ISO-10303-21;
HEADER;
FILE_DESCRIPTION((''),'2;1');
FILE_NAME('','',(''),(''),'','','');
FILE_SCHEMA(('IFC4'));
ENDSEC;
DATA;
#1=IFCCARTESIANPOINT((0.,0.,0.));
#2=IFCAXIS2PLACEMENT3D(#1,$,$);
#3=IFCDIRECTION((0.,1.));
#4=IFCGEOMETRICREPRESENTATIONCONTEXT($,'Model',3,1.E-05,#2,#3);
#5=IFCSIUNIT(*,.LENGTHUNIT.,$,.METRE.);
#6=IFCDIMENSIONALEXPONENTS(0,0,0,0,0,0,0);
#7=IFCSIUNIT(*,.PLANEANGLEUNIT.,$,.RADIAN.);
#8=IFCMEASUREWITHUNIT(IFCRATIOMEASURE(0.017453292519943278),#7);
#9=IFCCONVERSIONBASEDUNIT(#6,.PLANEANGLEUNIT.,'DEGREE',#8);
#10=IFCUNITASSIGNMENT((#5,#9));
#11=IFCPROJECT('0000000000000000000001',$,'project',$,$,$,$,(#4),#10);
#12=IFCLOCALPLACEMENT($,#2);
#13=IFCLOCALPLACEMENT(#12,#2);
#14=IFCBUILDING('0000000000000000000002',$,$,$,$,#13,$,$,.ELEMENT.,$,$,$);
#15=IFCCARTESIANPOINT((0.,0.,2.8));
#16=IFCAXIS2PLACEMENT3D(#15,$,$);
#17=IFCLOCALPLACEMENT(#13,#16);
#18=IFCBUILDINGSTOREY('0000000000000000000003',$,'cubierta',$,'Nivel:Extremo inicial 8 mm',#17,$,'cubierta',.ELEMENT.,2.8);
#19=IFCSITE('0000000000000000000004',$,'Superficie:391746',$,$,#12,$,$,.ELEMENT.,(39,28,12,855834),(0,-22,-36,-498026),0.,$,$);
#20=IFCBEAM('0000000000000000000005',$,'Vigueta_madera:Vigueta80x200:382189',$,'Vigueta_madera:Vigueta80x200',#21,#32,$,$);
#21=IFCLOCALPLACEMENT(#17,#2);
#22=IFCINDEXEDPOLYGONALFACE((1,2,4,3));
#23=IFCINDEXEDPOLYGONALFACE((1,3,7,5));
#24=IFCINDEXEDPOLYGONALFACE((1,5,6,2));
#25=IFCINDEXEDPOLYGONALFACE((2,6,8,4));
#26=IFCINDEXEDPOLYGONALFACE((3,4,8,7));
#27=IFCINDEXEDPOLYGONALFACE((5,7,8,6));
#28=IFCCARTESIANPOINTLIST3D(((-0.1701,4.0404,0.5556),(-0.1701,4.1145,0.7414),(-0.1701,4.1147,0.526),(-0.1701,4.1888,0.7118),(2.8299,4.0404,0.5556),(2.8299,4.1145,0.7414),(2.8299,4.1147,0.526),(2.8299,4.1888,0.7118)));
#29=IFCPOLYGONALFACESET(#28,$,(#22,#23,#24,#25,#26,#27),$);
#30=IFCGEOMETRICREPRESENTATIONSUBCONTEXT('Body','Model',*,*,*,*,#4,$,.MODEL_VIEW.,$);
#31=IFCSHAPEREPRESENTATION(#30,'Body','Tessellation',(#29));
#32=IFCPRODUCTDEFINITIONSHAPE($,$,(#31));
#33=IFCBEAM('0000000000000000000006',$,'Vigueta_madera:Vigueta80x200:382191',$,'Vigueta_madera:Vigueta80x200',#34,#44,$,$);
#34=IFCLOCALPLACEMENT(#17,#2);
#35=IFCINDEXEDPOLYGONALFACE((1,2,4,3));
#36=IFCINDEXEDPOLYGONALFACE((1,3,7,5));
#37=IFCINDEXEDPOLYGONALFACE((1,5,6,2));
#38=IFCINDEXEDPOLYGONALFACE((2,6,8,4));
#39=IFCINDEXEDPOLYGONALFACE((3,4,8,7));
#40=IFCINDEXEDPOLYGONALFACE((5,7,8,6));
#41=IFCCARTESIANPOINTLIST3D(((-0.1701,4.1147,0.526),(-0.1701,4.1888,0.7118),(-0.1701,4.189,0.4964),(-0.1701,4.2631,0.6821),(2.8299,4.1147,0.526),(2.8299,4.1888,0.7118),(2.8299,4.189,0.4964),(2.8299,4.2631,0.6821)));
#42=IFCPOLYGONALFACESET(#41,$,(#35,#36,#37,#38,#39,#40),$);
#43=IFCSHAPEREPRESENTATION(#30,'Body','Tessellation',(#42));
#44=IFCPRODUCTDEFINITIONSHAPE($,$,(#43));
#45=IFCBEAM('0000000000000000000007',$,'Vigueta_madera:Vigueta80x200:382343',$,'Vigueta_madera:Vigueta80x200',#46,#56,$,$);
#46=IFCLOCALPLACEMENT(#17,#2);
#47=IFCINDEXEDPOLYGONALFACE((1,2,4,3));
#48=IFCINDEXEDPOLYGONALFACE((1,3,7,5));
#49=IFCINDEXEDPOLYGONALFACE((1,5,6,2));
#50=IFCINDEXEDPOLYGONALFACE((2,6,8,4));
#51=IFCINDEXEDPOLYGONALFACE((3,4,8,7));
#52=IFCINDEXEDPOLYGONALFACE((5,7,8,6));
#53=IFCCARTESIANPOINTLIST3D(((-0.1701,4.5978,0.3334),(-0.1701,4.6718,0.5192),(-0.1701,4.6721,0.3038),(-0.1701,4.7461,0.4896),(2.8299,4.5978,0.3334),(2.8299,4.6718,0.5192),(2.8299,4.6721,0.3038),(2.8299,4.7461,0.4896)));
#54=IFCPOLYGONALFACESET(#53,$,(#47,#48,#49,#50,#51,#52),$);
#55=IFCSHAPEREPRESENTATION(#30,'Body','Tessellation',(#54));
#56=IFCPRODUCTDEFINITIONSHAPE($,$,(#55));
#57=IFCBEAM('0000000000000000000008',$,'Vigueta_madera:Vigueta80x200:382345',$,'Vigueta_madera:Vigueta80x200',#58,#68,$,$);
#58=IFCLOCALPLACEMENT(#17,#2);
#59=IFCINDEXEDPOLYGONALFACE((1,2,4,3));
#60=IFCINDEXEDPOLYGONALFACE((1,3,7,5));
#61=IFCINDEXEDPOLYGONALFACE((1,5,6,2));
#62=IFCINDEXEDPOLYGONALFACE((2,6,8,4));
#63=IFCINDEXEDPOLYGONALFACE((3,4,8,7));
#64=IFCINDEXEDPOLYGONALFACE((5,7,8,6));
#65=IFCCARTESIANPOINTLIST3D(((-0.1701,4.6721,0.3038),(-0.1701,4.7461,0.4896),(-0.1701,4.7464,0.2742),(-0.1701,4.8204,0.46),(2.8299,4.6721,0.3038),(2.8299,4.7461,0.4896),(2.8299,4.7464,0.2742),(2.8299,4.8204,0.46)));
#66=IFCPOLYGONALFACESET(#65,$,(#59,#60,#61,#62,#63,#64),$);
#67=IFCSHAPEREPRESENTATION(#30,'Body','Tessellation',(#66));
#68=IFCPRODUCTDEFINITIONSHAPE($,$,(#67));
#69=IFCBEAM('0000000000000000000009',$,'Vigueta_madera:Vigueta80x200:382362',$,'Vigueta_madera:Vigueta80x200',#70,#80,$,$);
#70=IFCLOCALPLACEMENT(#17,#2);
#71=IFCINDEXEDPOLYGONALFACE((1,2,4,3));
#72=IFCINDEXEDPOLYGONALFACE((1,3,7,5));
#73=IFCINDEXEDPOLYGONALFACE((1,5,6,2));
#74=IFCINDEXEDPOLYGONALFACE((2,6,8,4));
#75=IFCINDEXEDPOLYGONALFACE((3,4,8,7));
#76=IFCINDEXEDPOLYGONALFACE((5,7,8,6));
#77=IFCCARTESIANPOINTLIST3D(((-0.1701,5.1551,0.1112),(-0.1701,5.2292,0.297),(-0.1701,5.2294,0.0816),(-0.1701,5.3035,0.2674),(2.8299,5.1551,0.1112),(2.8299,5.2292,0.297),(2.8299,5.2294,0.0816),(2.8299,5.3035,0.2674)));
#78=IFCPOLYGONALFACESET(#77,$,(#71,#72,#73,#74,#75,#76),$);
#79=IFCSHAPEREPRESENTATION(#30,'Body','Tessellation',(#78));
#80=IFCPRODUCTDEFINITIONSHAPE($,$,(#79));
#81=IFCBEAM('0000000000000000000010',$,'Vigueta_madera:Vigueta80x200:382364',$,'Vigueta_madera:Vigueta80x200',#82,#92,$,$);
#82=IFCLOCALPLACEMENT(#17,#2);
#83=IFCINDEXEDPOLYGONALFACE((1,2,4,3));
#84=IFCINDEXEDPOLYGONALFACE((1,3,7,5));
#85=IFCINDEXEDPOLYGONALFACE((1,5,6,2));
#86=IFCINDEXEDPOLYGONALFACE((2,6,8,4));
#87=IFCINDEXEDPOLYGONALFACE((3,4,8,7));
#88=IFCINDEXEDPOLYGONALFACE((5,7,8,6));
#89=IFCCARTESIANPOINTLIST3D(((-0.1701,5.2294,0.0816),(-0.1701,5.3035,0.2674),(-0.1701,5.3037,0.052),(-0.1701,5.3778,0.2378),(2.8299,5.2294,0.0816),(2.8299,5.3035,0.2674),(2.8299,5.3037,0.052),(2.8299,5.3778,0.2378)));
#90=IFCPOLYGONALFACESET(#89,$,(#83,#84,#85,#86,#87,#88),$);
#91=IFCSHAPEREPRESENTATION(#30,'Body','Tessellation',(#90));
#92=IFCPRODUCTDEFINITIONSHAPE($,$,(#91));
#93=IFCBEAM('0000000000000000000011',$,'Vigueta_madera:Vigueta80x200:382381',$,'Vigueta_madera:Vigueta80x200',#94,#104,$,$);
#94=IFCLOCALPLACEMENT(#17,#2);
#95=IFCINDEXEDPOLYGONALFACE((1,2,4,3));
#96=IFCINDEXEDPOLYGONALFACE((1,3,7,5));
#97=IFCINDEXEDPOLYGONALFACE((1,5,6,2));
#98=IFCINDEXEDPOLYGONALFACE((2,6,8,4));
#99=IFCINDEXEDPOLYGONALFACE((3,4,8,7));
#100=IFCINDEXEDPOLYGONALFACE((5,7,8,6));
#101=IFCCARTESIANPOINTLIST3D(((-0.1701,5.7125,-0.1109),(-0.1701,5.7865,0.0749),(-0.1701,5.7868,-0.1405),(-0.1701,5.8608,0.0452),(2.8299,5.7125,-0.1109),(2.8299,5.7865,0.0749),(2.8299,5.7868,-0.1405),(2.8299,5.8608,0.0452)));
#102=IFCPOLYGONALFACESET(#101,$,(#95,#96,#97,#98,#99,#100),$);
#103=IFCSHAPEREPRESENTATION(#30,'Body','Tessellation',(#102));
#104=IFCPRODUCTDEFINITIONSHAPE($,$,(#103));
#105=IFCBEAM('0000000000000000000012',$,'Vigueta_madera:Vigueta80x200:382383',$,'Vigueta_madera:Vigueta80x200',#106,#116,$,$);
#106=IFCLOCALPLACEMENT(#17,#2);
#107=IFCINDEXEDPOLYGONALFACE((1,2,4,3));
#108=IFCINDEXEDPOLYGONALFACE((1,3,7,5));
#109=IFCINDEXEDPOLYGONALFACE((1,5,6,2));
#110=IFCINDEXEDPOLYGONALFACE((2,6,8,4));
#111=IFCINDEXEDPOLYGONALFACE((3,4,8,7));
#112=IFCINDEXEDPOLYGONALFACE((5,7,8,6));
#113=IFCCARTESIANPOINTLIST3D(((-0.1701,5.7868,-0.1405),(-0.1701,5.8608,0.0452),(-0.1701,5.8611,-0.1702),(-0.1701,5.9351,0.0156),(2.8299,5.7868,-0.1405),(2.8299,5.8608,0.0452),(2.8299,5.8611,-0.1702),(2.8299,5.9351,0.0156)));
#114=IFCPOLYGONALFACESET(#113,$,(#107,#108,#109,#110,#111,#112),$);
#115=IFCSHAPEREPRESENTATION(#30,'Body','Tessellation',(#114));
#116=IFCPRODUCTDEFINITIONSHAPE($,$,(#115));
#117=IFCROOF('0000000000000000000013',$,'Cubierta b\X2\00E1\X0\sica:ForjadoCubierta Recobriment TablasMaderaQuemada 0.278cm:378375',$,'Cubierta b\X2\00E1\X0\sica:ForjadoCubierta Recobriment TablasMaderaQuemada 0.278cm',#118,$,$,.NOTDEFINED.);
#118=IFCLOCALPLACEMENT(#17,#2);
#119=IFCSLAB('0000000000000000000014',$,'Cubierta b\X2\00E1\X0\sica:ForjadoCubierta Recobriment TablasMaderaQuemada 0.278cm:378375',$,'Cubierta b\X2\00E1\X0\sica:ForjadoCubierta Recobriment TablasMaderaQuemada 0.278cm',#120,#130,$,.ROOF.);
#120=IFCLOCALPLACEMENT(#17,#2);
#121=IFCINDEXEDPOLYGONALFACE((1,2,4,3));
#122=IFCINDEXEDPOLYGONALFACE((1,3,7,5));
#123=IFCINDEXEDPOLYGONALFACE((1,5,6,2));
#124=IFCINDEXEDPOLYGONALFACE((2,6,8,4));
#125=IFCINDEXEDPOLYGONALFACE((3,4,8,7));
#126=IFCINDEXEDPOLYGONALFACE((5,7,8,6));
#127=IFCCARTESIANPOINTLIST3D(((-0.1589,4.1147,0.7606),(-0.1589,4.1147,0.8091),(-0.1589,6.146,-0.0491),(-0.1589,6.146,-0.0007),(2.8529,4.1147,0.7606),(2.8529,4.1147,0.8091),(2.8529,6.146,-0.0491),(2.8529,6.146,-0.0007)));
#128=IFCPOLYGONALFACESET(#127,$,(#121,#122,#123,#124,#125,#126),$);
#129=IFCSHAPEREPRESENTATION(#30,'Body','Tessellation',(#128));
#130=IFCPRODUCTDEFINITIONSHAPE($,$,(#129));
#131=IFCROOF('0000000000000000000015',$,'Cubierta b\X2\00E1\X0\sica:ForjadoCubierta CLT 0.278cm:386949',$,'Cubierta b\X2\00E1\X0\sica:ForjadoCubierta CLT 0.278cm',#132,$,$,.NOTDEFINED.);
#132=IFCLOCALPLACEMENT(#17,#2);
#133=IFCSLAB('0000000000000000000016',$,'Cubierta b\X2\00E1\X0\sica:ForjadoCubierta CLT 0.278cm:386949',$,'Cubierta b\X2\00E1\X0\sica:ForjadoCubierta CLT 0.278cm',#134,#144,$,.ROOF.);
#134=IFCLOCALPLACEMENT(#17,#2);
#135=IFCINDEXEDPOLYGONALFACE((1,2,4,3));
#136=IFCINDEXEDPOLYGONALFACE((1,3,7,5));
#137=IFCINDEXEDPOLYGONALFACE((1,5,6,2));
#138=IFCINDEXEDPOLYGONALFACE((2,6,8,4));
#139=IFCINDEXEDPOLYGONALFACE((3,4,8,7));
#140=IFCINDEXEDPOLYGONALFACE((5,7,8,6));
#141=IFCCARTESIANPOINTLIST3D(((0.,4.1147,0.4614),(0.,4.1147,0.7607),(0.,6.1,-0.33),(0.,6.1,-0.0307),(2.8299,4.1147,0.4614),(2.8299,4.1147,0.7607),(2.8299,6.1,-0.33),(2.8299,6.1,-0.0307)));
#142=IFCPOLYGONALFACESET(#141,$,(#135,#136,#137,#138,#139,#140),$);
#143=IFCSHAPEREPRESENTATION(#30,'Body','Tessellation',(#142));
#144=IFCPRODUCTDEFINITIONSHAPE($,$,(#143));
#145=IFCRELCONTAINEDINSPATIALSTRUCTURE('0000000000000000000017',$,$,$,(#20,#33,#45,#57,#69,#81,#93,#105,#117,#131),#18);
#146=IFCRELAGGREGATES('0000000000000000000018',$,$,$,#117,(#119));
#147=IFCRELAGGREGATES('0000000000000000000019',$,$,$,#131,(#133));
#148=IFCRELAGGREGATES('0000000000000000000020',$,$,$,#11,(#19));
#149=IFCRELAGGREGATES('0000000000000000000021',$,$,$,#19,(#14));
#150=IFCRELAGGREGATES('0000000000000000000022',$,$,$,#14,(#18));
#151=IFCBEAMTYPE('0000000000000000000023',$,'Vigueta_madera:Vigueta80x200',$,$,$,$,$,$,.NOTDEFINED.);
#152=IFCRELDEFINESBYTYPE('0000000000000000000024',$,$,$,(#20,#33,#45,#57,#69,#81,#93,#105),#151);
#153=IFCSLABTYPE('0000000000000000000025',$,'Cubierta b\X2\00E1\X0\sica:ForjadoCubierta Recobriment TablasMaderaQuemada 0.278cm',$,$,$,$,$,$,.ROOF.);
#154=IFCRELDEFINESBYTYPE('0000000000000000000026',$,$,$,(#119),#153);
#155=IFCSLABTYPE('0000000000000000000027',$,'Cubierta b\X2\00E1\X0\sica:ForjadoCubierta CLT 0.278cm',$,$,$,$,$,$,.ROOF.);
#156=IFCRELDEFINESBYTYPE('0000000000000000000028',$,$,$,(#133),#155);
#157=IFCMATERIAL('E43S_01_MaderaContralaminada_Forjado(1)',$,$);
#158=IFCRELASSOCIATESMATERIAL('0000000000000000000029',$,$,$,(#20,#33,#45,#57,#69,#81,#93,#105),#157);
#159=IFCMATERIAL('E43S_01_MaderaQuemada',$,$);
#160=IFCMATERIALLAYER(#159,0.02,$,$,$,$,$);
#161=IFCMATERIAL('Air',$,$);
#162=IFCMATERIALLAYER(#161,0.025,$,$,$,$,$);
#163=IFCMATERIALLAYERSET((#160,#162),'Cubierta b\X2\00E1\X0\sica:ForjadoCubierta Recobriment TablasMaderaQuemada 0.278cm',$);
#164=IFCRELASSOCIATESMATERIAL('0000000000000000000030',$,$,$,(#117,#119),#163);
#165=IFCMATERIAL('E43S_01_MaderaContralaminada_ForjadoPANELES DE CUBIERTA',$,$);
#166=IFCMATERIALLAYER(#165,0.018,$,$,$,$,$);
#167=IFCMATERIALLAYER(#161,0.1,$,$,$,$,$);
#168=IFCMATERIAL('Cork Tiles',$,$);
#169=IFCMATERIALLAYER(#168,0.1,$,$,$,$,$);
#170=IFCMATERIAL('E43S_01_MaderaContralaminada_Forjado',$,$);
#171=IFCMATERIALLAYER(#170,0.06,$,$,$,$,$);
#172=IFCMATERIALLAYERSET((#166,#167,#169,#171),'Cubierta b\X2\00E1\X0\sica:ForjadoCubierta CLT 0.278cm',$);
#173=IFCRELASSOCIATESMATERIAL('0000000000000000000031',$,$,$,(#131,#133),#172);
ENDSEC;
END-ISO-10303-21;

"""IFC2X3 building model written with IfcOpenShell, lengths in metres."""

from ifc_helpers import new_model, entity, si_unit, converted_unit, direction, frame, frame_2d, origin, place, context, subcontext, project, spatial, rectangle, extrude, material, layer, layer_set, type_object, element, aggregate, save


model = new_model("IFC2X3")

# Units and contexts
model_context = context("Model", 3, precision=1e-05, world=origin(), true_north=direction((0.0, 1.0)))
body_context = subcontext(model_context, "Body", "Model", "MODEL_VIEW")
ifc_project = project(units=[si_unit("LENGTHUNIT", "METRE"), converted_unit("PLANEANGLEUNIT", "DEGREE", entity("IfcRatioMeasure", 0.017453292519943278), si_unit("PLANEANGLEUNIT", "RADIAN"), dimensions=[0, 0, 0, 0, 0, 0, 0])], contexts=[model_context])

# Site, building, storey
site_placement = place(None, origin())
site = spatial("IfcSite", under=ifc_project, at=site_placement, Name="Superficie:391746", CompositionType="ELEMENT", RefLatitude=(39, 28, 12, 855834), RefLongitude=(0, -22, -36, -498026), RefElevation=0.0)
building_placement = place(site_placement, origin())
building = spatial("IfcBuilding", under=site, at=building_placement, CompositionType="ELEMENT")
storey_placement = place(building_placement, frame((0.0, 0.0, 2.8)))
storey = spatial("IfcBuildingStorey", under=building, at=storey_placement, Name="cubierta", ObjectType="Nivel:Extremo inicial 8 mm", LongName="cubierta", CompositionType="ELEMENT", Elevation=2.8)

# Beams
ifc_material_1 = material(Name="E43S_01_MaderaContralaminada_Forjado(1)")
beam_type = type_object("IfcBeamType", Name="Vigueta_madera:Vigueta80x200", PredefinedType="NOTDEFINED")
for number, where, name in (
    (1, (-0.1701, 4.1516, 0.7266), "Vigueta_madera:Vigueta80x200:382189"),
    (2, (-0.1701, 4.2259, 0.697), "Vigueta_madera:Vigueta80x200:382191"),
    (3, (-0.1701, 4.709, 0.5044), "Vigueta_madera:Vigueta80x200:382343"),
    (4, (-0.1701, 4.7833, 0.4748), "Vigueta_madera:Vigueta80x200:382345"),
):
    element("IfcBeam", number, at=place(storey_placement, frame(where)), inside=storey, type_object=beam_type, material=ifc_material_1, Name=name, ObjectType="Vigueta_madera:Vigueta80x200", context=body_context, shape_type="SweptSolid", body=[
        extrude(rectangle(XDim=0.2, YDim=0.08, at=frame_2d((0.0, 0.0), x_axis=(0.0, 1.0))), frame((0.0, -0.037, -0.0929), z_axis=(1.0, 0.0, 0.0), x_axis=(0.0, -0.928939, 0.370233)), (0.0, 0.0, 1.0), 3.0),
    ])
for number, where, name in (
    (5, (-0.1701, 5.2663, 0.2822), "Vigueta_madera:Vigueta80x200:382362"),
    (6, (-0.1701, 5.3406, 0.2526), "Vigueta_madera:Vigueta80x200:382364"),
    (7, (-0.1701, 5.8237, 0.0601), "Vigueta_madera:Vigueta80x200:382381"),
    (8, (-0.1701, 5.898, 0.0304), "Vigueta_madera:Vigueta80x200:382383"),
):
    element("IfcBeam", number, at=place(storey_placement, frame(where)), inside=storey, type_object=beam_type, material=ifc_material_1, Name=name, ObjectType="Vigueta_madera:Vigueta80x200", context=body_context, shape_type="SweptSolid", body=[
        extrude(rectangle(XDim=0.2, YDim=0.08, at=frame_2d((0.0, 0.0), x_axis=(0.0, 1.0))), frame((0.0, -0.037, -0.0929), z_axis=(1.0, 0.0, 0.0), x_axis=(0.0, -0.928939, 0.370233)), (0.0, 0.0, 1.0), 3.0),
    ])

# Roofs, slabs
ifc_material_2 = material(Name="E43S_01_MaderaQuemada")
ifc_layer_1 = layer(ifc_material_2, 0.02)
ifc_material_3 = material(Name="Air")
ifc_layer_2 = layer(ifc_material_3, 0.025)
ifc_layer_set_1 = layer_set([ifc_layer_1, ifc_layer_2], Name="Cubierta básica:ForjadoCubierta Recobriment TablasMaderaQuemada 0.278cm")
roof_1_placement = place(storey_placement, frame((-0.1589, 4.1147, -0.0491)))
roof_1 = element("IfcRoof", 9, at=roof_1_placement, inside=storey, material=ifc_layer_set_1, Name="Cubierta básica:ForjadoCubierta Recobriment TablasMaderaQuemada 0.278cm:378375", ObjectType="Cubierta básica:ForjadoCubierta Recobriment TablasMaderaQuemada 0.278cm", ShapeType="NOTDEFINED")
slab_type_1 = type_object("IfcSlabType", Name="Cubierta básica:ForjadoCubierta Recobriment TablasMaderaQuemada 0.278cm", PredefinedType="ROOF")
slab_1_placement = place(roof_1_placement, origin())
slab_1 = element("IfcSlab", 10, at=slab_1_placement, type_object=slab_type_1, material=ifc_layer_set_1, Name="Cubierta básica:ForjadoCubierta Recobriment TablasMaderaQuemada 0.278cm:378375", ObjectType="Cubierta básica:ForjadoCubierta Recobriment TablasMaderaQuemada 0.278cm", PredefinedType="ROOF", context=body_context, shape_type="SweptSolid", body=[
    extrude(rectangle(XDim=2.1867, YDim=3.0118, at=frame_2d((0.0, 0.0), x_axis=(0.0, 1.0))), frame((1.5059, 1.0156, 0.4049), z_axis=(0.0, 0.370288, 0.928917), x_axis=(1.0, 0.0, 0.0)), (0.0, -0.370288, 0.928917), 0.0484),
])
aggregate(roof_1, [slab_1])
ifc_material_4 = material(Name="E43S_01_MaderaContralaminada_ForjadoPANELES DE CUBIERTA")
ifc_layer_3 = layer(ifc_material_4, 0.018)
ifc_layer_4 = layer(ifc_material_3, 0.1)
ifc_material_5 = material(Name="Cork Tiles")
ifc_layer_5 = layer(ifc_material_5, 0.1)
ifc_material_6 = material(Name="E43S_01_MaderaContralaminada_Forjado")
ifc_layer_6 = layer(ifc_material_6, 0.06)
ifc_layer_set_2 = layer_set([ifc_layer_3, ifc_layer_4, ifc_layer_5, ifc_layer_6], Name="Cubierta básica:ForjadoCubierta CLT 0.278cm")
roof_2_placement = place(storey_placement, frame((0.0, 4.1147, -0.33)))
roof_2 = element("IfcRoof", 11, at=roof_2_placement, inside=storey, material=ifc_layer_set_2, Name="Cubierta básica:ForjadoCubierta CLT 0.278cm:386949", ObjectType="Cubierta básica:ForjadoCubierta CLT 0.278cm", ShapeType="NOTDEFINED")
slab_type_2 = type_object("IfcSlabType", Name="Cubierta básica:ForjadoCubierta CLT 0.278cm", PredefinedType="ROOF")
slab_2_placement = place(roof_2_placement, origin())
slab_2 = element("IfcSlab", 12, at=slab_2_placement, type_object=slab_type_2, material=ifc_layer_set_2, Name="Cubierta básica:ForjadoCubierta CLT 0.278cm:386949", ObjectType="Cubierta básica:ForjadoCubierta CLT 0.278cm", PredefinedType="ROOF", context=body_context, shape_type="SweptSolid", body=[
    extrude(rectangle(XDim=2.1372, YDim=2.8299, at=frame_2d((0.0, 0.0), x_axis=(0.0, 1.0))), frame((1.415, 0.9926, 0.3957), z_axis=(0.0, 0.370288, 0.928917), x_axis=(1.0, 0.0, 0.0)), (0.0, -0.370288, 0.928917), 0.2993),
])
aggregate(roof_2, [slab_2])

save(model, "model.ifc")
